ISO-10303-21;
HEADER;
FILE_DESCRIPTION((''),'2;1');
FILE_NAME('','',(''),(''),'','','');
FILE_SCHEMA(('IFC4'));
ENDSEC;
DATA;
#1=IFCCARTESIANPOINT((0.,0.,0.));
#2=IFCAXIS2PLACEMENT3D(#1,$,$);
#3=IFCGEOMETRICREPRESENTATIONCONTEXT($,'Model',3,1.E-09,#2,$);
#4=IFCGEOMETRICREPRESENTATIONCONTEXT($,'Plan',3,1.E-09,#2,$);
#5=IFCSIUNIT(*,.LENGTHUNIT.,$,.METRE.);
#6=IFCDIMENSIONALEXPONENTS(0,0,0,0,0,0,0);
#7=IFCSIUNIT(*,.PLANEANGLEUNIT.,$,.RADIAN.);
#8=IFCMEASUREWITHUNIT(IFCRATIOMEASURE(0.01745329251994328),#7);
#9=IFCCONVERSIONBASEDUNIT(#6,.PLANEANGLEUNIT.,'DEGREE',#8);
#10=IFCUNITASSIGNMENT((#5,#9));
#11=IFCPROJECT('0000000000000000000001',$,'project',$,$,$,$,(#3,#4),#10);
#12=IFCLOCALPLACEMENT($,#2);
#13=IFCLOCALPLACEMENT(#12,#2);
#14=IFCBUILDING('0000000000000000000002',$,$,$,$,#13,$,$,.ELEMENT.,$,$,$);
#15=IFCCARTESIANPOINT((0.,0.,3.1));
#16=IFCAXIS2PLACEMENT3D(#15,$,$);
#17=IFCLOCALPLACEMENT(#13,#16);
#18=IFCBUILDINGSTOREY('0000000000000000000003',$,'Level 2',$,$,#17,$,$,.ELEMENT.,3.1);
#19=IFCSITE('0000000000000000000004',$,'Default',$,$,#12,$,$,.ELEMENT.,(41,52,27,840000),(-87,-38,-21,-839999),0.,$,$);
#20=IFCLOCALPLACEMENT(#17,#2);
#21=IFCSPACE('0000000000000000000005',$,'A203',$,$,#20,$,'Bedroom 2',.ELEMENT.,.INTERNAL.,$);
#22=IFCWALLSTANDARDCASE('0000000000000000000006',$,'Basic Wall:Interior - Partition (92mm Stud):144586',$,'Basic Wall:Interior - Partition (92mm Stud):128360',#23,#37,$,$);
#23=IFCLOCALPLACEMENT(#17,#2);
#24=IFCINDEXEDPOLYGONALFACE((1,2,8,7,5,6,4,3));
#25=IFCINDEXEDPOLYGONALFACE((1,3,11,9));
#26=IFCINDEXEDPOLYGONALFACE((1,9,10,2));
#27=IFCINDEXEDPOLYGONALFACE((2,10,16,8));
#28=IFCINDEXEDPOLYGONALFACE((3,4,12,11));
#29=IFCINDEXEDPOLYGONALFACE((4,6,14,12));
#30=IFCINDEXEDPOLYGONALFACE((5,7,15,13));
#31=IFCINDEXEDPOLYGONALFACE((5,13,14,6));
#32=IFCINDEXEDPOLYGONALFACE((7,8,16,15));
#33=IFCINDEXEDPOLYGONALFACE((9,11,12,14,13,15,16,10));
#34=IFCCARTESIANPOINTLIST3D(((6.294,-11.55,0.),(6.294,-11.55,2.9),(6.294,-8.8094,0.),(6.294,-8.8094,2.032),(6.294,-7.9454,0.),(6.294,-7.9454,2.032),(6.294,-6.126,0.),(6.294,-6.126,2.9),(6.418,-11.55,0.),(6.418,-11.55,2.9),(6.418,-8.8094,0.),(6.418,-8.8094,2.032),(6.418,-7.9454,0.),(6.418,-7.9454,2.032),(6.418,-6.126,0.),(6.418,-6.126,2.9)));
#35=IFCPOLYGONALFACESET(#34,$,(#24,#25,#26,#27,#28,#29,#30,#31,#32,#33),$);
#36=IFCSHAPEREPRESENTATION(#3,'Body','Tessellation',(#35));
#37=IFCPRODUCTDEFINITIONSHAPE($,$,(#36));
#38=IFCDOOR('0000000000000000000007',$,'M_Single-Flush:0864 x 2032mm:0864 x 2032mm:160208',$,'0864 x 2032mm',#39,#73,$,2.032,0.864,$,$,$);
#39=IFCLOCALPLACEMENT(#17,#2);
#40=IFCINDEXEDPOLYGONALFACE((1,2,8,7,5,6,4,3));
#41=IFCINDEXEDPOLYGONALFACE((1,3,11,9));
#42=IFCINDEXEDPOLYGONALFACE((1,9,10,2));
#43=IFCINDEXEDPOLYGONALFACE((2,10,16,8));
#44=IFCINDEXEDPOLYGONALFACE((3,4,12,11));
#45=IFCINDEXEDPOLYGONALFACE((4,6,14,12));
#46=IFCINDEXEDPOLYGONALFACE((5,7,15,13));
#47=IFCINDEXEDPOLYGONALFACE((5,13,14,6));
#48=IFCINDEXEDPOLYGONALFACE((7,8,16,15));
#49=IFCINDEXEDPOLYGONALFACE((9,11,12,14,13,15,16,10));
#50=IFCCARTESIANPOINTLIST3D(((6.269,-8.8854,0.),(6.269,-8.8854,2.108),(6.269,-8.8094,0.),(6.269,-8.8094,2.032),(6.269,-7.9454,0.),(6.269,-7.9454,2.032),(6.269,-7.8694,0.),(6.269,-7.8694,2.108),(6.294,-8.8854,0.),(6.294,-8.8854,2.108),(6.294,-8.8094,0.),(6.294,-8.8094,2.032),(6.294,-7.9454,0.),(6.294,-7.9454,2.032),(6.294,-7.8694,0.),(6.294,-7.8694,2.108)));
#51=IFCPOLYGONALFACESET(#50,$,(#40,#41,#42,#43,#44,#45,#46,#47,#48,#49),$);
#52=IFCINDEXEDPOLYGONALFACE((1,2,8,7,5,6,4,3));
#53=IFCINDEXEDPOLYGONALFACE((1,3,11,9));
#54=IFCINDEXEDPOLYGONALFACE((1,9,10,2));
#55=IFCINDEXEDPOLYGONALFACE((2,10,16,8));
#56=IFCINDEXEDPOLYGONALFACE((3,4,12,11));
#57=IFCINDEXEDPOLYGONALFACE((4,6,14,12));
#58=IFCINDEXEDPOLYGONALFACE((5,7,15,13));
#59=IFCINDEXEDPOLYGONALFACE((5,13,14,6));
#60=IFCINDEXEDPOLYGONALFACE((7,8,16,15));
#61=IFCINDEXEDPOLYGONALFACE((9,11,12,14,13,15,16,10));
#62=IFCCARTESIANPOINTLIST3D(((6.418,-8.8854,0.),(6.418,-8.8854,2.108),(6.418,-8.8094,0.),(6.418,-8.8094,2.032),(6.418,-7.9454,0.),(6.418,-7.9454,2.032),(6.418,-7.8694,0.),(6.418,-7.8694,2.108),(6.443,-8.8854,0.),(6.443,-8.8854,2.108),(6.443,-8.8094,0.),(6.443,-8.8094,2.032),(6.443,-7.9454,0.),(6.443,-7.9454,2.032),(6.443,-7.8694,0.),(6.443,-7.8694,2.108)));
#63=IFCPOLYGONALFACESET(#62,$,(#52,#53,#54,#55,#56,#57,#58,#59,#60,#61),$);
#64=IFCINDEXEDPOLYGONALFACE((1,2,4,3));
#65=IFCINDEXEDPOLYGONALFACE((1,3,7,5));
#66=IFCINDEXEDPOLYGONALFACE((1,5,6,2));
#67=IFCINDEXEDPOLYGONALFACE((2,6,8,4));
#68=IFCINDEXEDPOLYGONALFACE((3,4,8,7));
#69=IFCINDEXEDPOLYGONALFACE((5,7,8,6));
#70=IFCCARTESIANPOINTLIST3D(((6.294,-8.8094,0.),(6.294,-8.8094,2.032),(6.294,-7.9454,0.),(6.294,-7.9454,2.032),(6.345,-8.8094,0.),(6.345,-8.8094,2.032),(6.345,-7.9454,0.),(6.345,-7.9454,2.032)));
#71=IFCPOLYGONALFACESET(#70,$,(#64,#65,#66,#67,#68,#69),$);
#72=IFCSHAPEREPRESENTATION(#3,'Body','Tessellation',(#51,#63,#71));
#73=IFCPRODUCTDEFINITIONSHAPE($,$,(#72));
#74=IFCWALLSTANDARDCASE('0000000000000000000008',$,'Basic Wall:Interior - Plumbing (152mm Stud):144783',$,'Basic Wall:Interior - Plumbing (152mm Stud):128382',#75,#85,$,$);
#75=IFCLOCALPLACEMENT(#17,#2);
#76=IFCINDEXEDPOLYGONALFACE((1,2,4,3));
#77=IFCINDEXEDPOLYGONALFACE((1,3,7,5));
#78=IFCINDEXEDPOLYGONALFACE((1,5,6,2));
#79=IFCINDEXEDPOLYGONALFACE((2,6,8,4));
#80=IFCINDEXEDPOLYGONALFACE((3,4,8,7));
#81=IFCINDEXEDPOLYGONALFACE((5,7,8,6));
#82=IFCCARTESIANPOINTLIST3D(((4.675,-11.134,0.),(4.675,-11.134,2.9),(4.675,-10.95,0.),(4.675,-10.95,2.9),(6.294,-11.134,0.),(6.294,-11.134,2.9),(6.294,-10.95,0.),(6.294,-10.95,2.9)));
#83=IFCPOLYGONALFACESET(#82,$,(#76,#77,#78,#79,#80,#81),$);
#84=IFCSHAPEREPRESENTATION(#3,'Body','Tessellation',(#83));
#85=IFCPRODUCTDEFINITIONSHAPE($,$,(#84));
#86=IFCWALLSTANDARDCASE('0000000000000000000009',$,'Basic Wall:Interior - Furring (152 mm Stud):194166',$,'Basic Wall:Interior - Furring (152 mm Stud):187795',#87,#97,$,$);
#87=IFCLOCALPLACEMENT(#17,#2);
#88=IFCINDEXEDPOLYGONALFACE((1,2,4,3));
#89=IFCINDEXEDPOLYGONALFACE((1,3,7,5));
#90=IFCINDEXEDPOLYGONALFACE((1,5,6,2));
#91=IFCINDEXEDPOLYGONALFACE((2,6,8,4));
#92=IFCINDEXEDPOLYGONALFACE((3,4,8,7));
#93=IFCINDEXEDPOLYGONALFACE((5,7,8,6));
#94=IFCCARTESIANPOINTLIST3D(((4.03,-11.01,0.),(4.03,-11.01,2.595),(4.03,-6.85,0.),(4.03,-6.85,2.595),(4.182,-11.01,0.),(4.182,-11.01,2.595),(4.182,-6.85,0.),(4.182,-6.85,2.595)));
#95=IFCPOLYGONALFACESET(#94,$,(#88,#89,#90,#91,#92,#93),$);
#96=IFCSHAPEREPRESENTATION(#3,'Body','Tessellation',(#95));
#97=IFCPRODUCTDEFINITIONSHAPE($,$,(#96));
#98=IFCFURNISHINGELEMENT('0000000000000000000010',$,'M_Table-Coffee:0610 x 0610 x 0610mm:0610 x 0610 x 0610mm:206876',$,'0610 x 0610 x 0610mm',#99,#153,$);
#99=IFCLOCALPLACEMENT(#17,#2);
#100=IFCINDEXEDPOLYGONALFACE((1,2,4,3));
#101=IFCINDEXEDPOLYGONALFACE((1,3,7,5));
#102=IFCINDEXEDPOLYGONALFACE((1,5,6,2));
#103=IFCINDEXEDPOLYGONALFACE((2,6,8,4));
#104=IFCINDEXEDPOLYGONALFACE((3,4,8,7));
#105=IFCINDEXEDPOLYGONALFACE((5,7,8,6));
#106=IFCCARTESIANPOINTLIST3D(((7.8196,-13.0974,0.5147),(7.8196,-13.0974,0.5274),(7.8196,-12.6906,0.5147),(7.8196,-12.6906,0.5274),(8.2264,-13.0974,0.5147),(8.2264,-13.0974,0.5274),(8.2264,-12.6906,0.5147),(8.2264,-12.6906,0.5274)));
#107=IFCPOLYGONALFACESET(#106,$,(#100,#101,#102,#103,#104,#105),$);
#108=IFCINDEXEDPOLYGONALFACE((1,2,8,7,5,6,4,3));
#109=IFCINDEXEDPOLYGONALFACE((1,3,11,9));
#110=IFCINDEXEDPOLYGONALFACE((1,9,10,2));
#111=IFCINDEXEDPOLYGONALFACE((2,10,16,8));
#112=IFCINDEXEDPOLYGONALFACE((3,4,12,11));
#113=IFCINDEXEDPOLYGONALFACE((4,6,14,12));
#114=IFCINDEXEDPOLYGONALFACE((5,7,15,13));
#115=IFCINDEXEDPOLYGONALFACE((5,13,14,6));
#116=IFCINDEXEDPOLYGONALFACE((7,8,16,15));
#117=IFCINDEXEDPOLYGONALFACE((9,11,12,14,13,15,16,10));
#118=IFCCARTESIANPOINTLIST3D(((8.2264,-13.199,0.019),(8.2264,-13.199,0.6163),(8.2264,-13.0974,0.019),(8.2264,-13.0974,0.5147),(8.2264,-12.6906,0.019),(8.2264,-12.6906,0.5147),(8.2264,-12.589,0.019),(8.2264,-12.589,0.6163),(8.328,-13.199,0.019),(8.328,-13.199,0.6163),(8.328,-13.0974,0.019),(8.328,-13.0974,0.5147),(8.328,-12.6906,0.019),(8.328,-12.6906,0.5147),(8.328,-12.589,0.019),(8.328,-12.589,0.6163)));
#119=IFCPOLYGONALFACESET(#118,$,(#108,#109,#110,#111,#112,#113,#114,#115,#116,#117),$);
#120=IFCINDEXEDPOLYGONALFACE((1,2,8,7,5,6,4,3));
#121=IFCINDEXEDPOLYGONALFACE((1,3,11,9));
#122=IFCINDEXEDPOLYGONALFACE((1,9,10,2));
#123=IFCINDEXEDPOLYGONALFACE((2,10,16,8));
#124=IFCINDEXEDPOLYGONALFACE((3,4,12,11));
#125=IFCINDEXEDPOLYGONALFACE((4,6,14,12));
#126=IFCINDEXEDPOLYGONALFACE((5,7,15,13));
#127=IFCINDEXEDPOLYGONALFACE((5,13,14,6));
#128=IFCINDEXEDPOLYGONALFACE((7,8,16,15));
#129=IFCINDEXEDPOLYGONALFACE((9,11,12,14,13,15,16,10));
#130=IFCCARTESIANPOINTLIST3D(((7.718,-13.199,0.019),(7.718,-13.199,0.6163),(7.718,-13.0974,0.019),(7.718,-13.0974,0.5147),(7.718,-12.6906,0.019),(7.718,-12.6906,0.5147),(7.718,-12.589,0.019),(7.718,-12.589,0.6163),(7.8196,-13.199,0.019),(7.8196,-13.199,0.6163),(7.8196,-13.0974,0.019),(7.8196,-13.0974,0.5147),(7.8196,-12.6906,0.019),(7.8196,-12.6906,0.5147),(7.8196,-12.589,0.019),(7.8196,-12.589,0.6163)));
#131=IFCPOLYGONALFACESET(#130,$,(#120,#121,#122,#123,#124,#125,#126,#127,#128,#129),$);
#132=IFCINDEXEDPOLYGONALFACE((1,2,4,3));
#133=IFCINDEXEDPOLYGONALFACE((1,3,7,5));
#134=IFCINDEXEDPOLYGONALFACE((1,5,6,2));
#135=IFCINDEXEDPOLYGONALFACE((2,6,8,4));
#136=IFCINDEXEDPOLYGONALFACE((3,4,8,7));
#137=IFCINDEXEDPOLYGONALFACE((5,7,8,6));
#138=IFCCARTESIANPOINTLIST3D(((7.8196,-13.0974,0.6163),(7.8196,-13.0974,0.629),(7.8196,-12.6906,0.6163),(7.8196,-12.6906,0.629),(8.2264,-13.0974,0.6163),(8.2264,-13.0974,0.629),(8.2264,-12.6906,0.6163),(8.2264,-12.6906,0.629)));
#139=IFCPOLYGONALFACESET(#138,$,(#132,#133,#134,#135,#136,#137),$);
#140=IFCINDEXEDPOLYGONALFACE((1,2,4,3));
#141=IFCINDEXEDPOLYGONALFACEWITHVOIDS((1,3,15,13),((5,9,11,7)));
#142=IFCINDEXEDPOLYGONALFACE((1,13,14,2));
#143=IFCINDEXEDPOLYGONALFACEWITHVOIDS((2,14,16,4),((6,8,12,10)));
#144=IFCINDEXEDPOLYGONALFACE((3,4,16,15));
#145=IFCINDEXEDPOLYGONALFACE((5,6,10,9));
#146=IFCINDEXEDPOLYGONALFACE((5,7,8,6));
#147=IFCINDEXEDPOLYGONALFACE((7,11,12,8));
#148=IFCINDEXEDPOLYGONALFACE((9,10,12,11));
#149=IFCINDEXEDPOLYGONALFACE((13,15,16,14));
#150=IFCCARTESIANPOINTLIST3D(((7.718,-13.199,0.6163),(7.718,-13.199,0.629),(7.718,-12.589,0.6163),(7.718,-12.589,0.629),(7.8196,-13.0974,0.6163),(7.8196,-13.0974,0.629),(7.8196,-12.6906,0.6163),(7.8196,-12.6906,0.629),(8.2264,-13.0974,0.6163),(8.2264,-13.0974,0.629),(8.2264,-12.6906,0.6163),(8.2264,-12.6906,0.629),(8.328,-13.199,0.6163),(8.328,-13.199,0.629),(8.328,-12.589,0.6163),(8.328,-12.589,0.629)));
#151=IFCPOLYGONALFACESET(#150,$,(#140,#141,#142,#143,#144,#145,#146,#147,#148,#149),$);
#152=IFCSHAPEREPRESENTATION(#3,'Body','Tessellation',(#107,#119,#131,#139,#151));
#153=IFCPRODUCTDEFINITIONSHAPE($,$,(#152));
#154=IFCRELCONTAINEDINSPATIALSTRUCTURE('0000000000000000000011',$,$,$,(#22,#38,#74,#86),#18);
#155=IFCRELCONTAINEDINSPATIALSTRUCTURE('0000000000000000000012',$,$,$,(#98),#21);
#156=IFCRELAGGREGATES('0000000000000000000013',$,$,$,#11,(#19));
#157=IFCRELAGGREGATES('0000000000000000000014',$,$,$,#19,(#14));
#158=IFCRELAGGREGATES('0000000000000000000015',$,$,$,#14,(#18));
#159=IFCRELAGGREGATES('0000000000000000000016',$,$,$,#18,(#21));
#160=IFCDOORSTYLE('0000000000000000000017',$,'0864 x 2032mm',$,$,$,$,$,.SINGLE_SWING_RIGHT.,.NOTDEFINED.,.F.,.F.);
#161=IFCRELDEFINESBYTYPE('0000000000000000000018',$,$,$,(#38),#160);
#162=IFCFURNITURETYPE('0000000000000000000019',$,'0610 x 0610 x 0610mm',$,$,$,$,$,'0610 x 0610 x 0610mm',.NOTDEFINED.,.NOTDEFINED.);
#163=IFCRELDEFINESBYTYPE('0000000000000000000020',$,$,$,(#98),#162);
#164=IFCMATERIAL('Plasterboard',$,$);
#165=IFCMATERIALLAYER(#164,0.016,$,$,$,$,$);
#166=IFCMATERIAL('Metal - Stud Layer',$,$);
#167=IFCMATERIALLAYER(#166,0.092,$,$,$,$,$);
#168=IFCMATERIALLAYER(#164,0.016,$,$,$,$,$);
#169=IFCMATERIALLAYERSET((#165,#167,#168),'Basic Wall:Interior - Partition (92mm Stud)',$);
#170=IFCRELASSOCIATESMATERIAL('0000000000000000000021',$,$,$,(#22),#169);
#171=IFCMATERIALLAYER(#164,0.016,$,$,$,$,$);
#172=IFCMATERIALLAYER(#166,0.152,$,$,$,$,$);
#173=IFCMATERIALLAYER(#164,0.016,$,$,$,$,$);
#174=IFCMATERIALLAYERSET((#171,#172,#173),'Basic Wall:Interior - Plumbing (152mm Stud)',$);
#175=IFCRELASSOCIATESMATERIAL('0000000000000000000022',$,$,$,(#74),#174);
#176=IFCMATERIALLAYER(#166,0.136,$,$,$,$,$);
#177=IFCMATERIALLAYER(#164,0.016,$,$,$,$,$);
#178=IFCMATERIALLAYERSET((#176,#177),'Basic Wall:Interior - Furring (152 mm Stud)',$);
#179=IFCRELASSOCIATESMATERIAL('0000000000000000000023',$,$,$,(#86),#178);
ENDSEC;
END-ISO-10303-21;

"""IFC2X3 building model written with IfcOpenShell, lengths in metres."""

from ifc_helpers import new_model, entity, si_unit, converted_unit, frame, frame_2d, origin, origin_2d_with_axis, place, context, project, spatial, polyline, rectangle, outline, extrude, source, transform, mapped, material, layer, layer_set, layer_usage, type_object, type_shapes, element, fill, save


model = new_model("IFC2X3")

# Units and contexts
model_context = context("Model", 3, precision=1e-09, world=origin())
plan_context = context("Plan", 3, precision=1e-09, world=origin())
ifc_project = project(units=[si_unit("LENGTHUNIT", "METRE"), converted_unit("PLANEANGLEUNIT", "DEGREE", entity("IfcRatioMeasure", 0.01745329251994328), si_unit("PLANEANGLEUNIT", "RADIAN"), dimensions=[0, 0, 0, 0, 0, 0, 0])], contexts=[model_context, plan_context])

# Site, building, storey
site_placement = place(None, origin())
site = spatial("IfcSite", under=ifc_project, at=site_placement, Name="Default", CompositionType="ELEMENT", RefLatitude=(41, 52, 27, 840000), RefLongitude=(-87, -38, -21, -839999), RefElevation=0.0)
building_placement = place(site_placement, origin())
building = spatial("IfcBuilding", under=site, at=building_placement, CompositionType="ELEMENT")
storey_placement = place(building_placement, frame((0.0, 0.0, 3.1)))
storey = spatial("IfcBuildingStorey", under=building, at=storey_placement, Name="Level 2", CompositionType="ELEMENT", Elevation=3.1)

# Shared definitions
ifc_material_1 = material(Name="Metal - Stud Layer")
ifc_material_2 = material(Name="Plasterboard")

# Shared definitions
ifc_layer_1 = layer(ifc_material_2, 0.016)
ifc_layer_2 = layer(ifc_material_1, 0.092)
ifc_layer_3 = layer(ifc_material_2, 0.016)
ifc_layer_set_1 = layer_set([ifc_layer_1, ifc_layer_2, ifc_layer_3], Name="Basic Wall:Interior - Partition (92mm Stud)")

# Wall, opening, door
ifc_layer_usage_1 = layer_usage(ifc_layer_set_1, "AXIS2", "NEGATIVE", 0.062)
wall_1_placement = place(storey_placement, frame((6.356, -11.55, 0.0), z_axis=(0.0, 0.0, 1.0), x_axis=(0.0, 1.0, 0.0)))
wall_1 = element("IfcWallStandardCase", 1, at=wall_1_placement, inside=storey, material=ifc_layer_usage_1, Name="Basic Wall:Interior - Partition (92mm Stud):144586", ObjectType="Basic Wall:Interior - Partition (92mm Stud):128360", context=model_context, shape_type="SweptSolid", body=[
    extrude(rectangle(XDim=5.424, YDim=0.124, at=frame_2d((2.712, 0.0), x_axis=(-1.0, 0.0))), origin(), (0.0, 0.0, 1.0), 2.9),
])
opening_1_placement = place(wall_1_placement, frame((2.7406, -0.062, 0.0)))
opening_1 = element("IfcOpeningElement", 2, at=opening_1_placement, cuts=wall_1, ObjectType="Opening", context=model_context, shape_type="SweptSolid", body=[
    extrude(rectangle(XDim=0.864, YDim=2.032, at=frame_2d((1.016, 0.432), x_axis=(0.0, 1.0))), frame((0.0, 0.0, 0.0), z_axis=(0.0, 1.0, 0.0), x_axis=(0.0, 0.0, 1.0)), (0.0, 0.0, 1.0), 0.124),
])
door_style = type_object("IfcDoorStyle", Name="0864 x 2032mm", ConstructionType="NOTDEFINED", OperationType="SINGLE_SWING_RIGHT", ParameterTakesPrecedence=False, Sizeable=False)
shared_shape_1 = source(origin(), model_context, "Body", "SweptSolid", [
    extrude(outline(polyline([(-0.508, -1.073), (0.508, -1.073), (0.508, 1.035), (0.432, 1.035), (0.432, -0.997), (-0.432, -0.997), (-0.432, 1.035), (-0.508, 1.035), (-0.508, -1.073)])), frame((0.432, 0.124, 1.035), z_axis=(0.0, 1.0, 0.0), x_axis=(1.0, 0.0, 0.0)), (0.0, 0.0, 1.0), 0.025),
    extrude(outline(polyline([(-1.073, -0.508), (1.035, -0.508), (1.035, -0.432), (-0.997, -0.432), (-0.997, 0.432), (1.035, 0.432), (1.035, 0.508), (-1.073, 0.508), (-1.073, -0.508)])), frame((0.432, -0.025, 1.035), z_axis=(0.0, 1.0, 0.0), x_axis=(0.0, 0.0, -1.0)), (0.0, 0.0, 1.0), 0.025),
    extrude(rectangle(XDim=0.051, YDim=0.864, at=origin_2d_with_axis()), frame((0.432, 0.0985, 0.0), z_axis=(0.0, 0.0, 1.0), x_axis=(0.0, 1.0, 0.0)), (0.0, 0.0, 1.0), 2.032),
])
type_shapes(door_style, [shared_shape_1])
door_placement = place(opening_1_placement, origin())
door = element("IfcDoor", 3, at=door_placement, inside=storey, type_object=door_style, Name="M_Single-Flush:0864 x 2032mm:0864 x 2032mm:160208", ObjectType="0864 x 2032mm", OverallHeight=2.032, OverallWidth=0.864, context=model_context, shape_type="MappedRepresentation", body=[
    mapped(shared_shape_1, transform((0.0, 0.0, 0.0), scale=1.0)),
])
fill(opening_1, door)

# Walls
ifc_layer_4 = layer(ifc_material_2, 0.016)
ifc_layer_5 = layer(ifc_material_1, 0.152)
ifc_layer_6 = layer(ifc_material_2, 0.016)
ifc_layer_set_2 = layer_set([ifc_layer_4, ifc_layer_5, ifc_layer_6], Name="Basic Wall:Interior - Plumbing (152mm Stud)")
ifc_layer_usage_2 = layer_usage(ifc_layer_set_2, "AXIS2", "NEGATIVE", 0.092)
wall_2_placement = place(storey_placement, frame((6.294, -11.042, 0.0), z_axis=(0.0, 0.0, 1.0), x_axis=(-1.0, 0.0, 0.0)))
element("IfcWallStandardCase", 4, at=wall_2_placement, inside=storey, material=ifc_layer_usage_2, Name="Basic Wall:Interior - Plumbing (152mm Stud):144783", ObjectType="Basic Wall:Interior - Plumbing (152mm Stud):128382", context=model_context, shape_type="SweptSolid", body=[
    extrude(rectangle(XDim=1.619, YDim=0.184, at=frame_2d((0.8095, 0.0), x_axis=(-1.0, 0.0))), origin(), (0.0, 0.0, 1.0), 2.9),
])
ifc_layer_7 = layer(ifc_material_1, 0.136)
ifc_layer_8 = layer(ifc_material_2, 0.016)
ifc_layer_set_3 = layer_set([ifc_layer_7, ifc_layer_8], Name="Basic Wall:Interior - Furring (152 mm Stud)")
ifc_layer_usage_3 = layer_usage(ifc_layer_set_3, "AXIS2", "POSITIVE", -0.076)
wall_3_placement = place(storey_placement, frame((4.106, -11.01, 0.0), z_axis=(0.0, 0.0, 1.0), x_axis=(0.0, 1.0, 0.0)))
element("IfcWallStandardCase", 5, at=wall_3_placement, inside=storey, material=ifc_layer_usage_3, Name="Basic Wall:Interior - Furring (152 mm Stud):194166", ObjectType="Basic Wall:Interior - Furring (152 mm Stud):187795", context=model_context, shape_type="SweptSolid", body=[
    extrude(rectangle(XDim=4.16, YDim=0.152, at=frame_2d((2.08, 0.0), x_axis=(-1.0, 0.0))), origin(), (0.0, 0.0, 1.0), 2.595),
])

# Shared definitions
space_placement = place(storey_placement, origin())
space = spatial("IfcSpace", under=storey, at=space_placement, Name="A203", LongName="Bedroom 2", CompositionType="ELEMENT", InteriorOrExteriorSpace="INTERNAL")

# Furnishing element
furniture_type = type_object("IfcFurnitureType", Name="0610 x 0610 x 0610mm", ElementType="0610 x 0610 x 0610mm", AssemblyPlace="NOTDEFINED")
shared_shape_2 = source(origin(), model_context, "Body", "SweptSolid", [
    extrude(rectangle(XDim=0.4068, YDim=0.4068, at=origin_2d_with_axis()), frame((0.0183, 0.0952, 0.4957), z_axis=(0.0, 0.0, 1.0), x_axis=(-1.0, 0.0, 0.0)), (0.0, 0.0, 1.0), 0.0127),
    extrude(outline(polyline([(-0.2732, -0.305), (0.324, -0.305), (0.324, 0.305), (-0.2732, 0.305), (-0.2732, 0.2034), (0.2225, 0.2034), (0.2225, -0.2034), (-0.2732, -0.2034), (-0.2732, -0.305)])), frame((0.2217, 0.0952, 0.2732), z_axis=(1.0, 0.0, 0.0), x_axis=(0.0, 0.0, 1.0)), (0.0, 0.0, 1.0), 0.1016),
    extrude(outline(polyline([(-0.305, -0.3241), (0.305, -0.3241), (0.305, 0.2733), (0.2034, 0.2733), (0.2034, -0.2224), (-0.2034, -0.2224), (-0.2034, 0.2733), (-0.305, 0.2733), (-0.305, -0.3241)])), frame((-0.2867, 0.0952, 0.2733), z_axis=(1.0, 0.0, 0.0), x_axis=(0.0, -1.0, 0.0)), (0.0, 0.0, 1.0), 0.1016),
    extrude(rectangle(XDim=0.4068, YDim=0.4068, at=origin_2d_with_axis()), frame((0.0183, 0.0952, 0.5973), z_axis=(0.0, 0.0, 1.0), x_axis=(-1.0, 0.0, 0.0)), (0.0, 0.0, 1.0), 0.0127),
    extrude(outline(polyline([(-0.305, -0.305), (0.305, -0.305), (0.305, 0.305), (-0.305, 0.305), (-0.305, -0.305)]), holes=[polyline([(-0.2034, -0.2034), (-0.2034, 0.2034), (0.2034, 0.2034), (0.2034, -0.2034), (-0.2034, -0.2034)])]), frame((0.0183, 0.0952, 0.5973), z_axis=(0.0, 0.0, 1.0), x_axis=(-1.0, 0.0, 0.0)), (0.0, 0.0, 1.0), 0.0127),
])
type_shapes(furniture_type, [shared_shape_2])
furnishing_placement = place(space_placement, frame((8.0047, -12.9892, 0.019)))
element("IfcFurnishingElement", 6, at=furnishing_placement, inside=space, type_object=furniture_type, Name="M_Table-Coffee:0610 x 0610 x 0610mm:0610 x 0610 x 0610mm:206876", ObjectType="0610 x 0610 x 0610mm", context=model_context, shape_type="MappedRepresentation", body=[
    mapped(shared_shape_2, transform((0.0, 0.0, 0.0), scale=1.0)),
])

save(model, "model.ifc")
